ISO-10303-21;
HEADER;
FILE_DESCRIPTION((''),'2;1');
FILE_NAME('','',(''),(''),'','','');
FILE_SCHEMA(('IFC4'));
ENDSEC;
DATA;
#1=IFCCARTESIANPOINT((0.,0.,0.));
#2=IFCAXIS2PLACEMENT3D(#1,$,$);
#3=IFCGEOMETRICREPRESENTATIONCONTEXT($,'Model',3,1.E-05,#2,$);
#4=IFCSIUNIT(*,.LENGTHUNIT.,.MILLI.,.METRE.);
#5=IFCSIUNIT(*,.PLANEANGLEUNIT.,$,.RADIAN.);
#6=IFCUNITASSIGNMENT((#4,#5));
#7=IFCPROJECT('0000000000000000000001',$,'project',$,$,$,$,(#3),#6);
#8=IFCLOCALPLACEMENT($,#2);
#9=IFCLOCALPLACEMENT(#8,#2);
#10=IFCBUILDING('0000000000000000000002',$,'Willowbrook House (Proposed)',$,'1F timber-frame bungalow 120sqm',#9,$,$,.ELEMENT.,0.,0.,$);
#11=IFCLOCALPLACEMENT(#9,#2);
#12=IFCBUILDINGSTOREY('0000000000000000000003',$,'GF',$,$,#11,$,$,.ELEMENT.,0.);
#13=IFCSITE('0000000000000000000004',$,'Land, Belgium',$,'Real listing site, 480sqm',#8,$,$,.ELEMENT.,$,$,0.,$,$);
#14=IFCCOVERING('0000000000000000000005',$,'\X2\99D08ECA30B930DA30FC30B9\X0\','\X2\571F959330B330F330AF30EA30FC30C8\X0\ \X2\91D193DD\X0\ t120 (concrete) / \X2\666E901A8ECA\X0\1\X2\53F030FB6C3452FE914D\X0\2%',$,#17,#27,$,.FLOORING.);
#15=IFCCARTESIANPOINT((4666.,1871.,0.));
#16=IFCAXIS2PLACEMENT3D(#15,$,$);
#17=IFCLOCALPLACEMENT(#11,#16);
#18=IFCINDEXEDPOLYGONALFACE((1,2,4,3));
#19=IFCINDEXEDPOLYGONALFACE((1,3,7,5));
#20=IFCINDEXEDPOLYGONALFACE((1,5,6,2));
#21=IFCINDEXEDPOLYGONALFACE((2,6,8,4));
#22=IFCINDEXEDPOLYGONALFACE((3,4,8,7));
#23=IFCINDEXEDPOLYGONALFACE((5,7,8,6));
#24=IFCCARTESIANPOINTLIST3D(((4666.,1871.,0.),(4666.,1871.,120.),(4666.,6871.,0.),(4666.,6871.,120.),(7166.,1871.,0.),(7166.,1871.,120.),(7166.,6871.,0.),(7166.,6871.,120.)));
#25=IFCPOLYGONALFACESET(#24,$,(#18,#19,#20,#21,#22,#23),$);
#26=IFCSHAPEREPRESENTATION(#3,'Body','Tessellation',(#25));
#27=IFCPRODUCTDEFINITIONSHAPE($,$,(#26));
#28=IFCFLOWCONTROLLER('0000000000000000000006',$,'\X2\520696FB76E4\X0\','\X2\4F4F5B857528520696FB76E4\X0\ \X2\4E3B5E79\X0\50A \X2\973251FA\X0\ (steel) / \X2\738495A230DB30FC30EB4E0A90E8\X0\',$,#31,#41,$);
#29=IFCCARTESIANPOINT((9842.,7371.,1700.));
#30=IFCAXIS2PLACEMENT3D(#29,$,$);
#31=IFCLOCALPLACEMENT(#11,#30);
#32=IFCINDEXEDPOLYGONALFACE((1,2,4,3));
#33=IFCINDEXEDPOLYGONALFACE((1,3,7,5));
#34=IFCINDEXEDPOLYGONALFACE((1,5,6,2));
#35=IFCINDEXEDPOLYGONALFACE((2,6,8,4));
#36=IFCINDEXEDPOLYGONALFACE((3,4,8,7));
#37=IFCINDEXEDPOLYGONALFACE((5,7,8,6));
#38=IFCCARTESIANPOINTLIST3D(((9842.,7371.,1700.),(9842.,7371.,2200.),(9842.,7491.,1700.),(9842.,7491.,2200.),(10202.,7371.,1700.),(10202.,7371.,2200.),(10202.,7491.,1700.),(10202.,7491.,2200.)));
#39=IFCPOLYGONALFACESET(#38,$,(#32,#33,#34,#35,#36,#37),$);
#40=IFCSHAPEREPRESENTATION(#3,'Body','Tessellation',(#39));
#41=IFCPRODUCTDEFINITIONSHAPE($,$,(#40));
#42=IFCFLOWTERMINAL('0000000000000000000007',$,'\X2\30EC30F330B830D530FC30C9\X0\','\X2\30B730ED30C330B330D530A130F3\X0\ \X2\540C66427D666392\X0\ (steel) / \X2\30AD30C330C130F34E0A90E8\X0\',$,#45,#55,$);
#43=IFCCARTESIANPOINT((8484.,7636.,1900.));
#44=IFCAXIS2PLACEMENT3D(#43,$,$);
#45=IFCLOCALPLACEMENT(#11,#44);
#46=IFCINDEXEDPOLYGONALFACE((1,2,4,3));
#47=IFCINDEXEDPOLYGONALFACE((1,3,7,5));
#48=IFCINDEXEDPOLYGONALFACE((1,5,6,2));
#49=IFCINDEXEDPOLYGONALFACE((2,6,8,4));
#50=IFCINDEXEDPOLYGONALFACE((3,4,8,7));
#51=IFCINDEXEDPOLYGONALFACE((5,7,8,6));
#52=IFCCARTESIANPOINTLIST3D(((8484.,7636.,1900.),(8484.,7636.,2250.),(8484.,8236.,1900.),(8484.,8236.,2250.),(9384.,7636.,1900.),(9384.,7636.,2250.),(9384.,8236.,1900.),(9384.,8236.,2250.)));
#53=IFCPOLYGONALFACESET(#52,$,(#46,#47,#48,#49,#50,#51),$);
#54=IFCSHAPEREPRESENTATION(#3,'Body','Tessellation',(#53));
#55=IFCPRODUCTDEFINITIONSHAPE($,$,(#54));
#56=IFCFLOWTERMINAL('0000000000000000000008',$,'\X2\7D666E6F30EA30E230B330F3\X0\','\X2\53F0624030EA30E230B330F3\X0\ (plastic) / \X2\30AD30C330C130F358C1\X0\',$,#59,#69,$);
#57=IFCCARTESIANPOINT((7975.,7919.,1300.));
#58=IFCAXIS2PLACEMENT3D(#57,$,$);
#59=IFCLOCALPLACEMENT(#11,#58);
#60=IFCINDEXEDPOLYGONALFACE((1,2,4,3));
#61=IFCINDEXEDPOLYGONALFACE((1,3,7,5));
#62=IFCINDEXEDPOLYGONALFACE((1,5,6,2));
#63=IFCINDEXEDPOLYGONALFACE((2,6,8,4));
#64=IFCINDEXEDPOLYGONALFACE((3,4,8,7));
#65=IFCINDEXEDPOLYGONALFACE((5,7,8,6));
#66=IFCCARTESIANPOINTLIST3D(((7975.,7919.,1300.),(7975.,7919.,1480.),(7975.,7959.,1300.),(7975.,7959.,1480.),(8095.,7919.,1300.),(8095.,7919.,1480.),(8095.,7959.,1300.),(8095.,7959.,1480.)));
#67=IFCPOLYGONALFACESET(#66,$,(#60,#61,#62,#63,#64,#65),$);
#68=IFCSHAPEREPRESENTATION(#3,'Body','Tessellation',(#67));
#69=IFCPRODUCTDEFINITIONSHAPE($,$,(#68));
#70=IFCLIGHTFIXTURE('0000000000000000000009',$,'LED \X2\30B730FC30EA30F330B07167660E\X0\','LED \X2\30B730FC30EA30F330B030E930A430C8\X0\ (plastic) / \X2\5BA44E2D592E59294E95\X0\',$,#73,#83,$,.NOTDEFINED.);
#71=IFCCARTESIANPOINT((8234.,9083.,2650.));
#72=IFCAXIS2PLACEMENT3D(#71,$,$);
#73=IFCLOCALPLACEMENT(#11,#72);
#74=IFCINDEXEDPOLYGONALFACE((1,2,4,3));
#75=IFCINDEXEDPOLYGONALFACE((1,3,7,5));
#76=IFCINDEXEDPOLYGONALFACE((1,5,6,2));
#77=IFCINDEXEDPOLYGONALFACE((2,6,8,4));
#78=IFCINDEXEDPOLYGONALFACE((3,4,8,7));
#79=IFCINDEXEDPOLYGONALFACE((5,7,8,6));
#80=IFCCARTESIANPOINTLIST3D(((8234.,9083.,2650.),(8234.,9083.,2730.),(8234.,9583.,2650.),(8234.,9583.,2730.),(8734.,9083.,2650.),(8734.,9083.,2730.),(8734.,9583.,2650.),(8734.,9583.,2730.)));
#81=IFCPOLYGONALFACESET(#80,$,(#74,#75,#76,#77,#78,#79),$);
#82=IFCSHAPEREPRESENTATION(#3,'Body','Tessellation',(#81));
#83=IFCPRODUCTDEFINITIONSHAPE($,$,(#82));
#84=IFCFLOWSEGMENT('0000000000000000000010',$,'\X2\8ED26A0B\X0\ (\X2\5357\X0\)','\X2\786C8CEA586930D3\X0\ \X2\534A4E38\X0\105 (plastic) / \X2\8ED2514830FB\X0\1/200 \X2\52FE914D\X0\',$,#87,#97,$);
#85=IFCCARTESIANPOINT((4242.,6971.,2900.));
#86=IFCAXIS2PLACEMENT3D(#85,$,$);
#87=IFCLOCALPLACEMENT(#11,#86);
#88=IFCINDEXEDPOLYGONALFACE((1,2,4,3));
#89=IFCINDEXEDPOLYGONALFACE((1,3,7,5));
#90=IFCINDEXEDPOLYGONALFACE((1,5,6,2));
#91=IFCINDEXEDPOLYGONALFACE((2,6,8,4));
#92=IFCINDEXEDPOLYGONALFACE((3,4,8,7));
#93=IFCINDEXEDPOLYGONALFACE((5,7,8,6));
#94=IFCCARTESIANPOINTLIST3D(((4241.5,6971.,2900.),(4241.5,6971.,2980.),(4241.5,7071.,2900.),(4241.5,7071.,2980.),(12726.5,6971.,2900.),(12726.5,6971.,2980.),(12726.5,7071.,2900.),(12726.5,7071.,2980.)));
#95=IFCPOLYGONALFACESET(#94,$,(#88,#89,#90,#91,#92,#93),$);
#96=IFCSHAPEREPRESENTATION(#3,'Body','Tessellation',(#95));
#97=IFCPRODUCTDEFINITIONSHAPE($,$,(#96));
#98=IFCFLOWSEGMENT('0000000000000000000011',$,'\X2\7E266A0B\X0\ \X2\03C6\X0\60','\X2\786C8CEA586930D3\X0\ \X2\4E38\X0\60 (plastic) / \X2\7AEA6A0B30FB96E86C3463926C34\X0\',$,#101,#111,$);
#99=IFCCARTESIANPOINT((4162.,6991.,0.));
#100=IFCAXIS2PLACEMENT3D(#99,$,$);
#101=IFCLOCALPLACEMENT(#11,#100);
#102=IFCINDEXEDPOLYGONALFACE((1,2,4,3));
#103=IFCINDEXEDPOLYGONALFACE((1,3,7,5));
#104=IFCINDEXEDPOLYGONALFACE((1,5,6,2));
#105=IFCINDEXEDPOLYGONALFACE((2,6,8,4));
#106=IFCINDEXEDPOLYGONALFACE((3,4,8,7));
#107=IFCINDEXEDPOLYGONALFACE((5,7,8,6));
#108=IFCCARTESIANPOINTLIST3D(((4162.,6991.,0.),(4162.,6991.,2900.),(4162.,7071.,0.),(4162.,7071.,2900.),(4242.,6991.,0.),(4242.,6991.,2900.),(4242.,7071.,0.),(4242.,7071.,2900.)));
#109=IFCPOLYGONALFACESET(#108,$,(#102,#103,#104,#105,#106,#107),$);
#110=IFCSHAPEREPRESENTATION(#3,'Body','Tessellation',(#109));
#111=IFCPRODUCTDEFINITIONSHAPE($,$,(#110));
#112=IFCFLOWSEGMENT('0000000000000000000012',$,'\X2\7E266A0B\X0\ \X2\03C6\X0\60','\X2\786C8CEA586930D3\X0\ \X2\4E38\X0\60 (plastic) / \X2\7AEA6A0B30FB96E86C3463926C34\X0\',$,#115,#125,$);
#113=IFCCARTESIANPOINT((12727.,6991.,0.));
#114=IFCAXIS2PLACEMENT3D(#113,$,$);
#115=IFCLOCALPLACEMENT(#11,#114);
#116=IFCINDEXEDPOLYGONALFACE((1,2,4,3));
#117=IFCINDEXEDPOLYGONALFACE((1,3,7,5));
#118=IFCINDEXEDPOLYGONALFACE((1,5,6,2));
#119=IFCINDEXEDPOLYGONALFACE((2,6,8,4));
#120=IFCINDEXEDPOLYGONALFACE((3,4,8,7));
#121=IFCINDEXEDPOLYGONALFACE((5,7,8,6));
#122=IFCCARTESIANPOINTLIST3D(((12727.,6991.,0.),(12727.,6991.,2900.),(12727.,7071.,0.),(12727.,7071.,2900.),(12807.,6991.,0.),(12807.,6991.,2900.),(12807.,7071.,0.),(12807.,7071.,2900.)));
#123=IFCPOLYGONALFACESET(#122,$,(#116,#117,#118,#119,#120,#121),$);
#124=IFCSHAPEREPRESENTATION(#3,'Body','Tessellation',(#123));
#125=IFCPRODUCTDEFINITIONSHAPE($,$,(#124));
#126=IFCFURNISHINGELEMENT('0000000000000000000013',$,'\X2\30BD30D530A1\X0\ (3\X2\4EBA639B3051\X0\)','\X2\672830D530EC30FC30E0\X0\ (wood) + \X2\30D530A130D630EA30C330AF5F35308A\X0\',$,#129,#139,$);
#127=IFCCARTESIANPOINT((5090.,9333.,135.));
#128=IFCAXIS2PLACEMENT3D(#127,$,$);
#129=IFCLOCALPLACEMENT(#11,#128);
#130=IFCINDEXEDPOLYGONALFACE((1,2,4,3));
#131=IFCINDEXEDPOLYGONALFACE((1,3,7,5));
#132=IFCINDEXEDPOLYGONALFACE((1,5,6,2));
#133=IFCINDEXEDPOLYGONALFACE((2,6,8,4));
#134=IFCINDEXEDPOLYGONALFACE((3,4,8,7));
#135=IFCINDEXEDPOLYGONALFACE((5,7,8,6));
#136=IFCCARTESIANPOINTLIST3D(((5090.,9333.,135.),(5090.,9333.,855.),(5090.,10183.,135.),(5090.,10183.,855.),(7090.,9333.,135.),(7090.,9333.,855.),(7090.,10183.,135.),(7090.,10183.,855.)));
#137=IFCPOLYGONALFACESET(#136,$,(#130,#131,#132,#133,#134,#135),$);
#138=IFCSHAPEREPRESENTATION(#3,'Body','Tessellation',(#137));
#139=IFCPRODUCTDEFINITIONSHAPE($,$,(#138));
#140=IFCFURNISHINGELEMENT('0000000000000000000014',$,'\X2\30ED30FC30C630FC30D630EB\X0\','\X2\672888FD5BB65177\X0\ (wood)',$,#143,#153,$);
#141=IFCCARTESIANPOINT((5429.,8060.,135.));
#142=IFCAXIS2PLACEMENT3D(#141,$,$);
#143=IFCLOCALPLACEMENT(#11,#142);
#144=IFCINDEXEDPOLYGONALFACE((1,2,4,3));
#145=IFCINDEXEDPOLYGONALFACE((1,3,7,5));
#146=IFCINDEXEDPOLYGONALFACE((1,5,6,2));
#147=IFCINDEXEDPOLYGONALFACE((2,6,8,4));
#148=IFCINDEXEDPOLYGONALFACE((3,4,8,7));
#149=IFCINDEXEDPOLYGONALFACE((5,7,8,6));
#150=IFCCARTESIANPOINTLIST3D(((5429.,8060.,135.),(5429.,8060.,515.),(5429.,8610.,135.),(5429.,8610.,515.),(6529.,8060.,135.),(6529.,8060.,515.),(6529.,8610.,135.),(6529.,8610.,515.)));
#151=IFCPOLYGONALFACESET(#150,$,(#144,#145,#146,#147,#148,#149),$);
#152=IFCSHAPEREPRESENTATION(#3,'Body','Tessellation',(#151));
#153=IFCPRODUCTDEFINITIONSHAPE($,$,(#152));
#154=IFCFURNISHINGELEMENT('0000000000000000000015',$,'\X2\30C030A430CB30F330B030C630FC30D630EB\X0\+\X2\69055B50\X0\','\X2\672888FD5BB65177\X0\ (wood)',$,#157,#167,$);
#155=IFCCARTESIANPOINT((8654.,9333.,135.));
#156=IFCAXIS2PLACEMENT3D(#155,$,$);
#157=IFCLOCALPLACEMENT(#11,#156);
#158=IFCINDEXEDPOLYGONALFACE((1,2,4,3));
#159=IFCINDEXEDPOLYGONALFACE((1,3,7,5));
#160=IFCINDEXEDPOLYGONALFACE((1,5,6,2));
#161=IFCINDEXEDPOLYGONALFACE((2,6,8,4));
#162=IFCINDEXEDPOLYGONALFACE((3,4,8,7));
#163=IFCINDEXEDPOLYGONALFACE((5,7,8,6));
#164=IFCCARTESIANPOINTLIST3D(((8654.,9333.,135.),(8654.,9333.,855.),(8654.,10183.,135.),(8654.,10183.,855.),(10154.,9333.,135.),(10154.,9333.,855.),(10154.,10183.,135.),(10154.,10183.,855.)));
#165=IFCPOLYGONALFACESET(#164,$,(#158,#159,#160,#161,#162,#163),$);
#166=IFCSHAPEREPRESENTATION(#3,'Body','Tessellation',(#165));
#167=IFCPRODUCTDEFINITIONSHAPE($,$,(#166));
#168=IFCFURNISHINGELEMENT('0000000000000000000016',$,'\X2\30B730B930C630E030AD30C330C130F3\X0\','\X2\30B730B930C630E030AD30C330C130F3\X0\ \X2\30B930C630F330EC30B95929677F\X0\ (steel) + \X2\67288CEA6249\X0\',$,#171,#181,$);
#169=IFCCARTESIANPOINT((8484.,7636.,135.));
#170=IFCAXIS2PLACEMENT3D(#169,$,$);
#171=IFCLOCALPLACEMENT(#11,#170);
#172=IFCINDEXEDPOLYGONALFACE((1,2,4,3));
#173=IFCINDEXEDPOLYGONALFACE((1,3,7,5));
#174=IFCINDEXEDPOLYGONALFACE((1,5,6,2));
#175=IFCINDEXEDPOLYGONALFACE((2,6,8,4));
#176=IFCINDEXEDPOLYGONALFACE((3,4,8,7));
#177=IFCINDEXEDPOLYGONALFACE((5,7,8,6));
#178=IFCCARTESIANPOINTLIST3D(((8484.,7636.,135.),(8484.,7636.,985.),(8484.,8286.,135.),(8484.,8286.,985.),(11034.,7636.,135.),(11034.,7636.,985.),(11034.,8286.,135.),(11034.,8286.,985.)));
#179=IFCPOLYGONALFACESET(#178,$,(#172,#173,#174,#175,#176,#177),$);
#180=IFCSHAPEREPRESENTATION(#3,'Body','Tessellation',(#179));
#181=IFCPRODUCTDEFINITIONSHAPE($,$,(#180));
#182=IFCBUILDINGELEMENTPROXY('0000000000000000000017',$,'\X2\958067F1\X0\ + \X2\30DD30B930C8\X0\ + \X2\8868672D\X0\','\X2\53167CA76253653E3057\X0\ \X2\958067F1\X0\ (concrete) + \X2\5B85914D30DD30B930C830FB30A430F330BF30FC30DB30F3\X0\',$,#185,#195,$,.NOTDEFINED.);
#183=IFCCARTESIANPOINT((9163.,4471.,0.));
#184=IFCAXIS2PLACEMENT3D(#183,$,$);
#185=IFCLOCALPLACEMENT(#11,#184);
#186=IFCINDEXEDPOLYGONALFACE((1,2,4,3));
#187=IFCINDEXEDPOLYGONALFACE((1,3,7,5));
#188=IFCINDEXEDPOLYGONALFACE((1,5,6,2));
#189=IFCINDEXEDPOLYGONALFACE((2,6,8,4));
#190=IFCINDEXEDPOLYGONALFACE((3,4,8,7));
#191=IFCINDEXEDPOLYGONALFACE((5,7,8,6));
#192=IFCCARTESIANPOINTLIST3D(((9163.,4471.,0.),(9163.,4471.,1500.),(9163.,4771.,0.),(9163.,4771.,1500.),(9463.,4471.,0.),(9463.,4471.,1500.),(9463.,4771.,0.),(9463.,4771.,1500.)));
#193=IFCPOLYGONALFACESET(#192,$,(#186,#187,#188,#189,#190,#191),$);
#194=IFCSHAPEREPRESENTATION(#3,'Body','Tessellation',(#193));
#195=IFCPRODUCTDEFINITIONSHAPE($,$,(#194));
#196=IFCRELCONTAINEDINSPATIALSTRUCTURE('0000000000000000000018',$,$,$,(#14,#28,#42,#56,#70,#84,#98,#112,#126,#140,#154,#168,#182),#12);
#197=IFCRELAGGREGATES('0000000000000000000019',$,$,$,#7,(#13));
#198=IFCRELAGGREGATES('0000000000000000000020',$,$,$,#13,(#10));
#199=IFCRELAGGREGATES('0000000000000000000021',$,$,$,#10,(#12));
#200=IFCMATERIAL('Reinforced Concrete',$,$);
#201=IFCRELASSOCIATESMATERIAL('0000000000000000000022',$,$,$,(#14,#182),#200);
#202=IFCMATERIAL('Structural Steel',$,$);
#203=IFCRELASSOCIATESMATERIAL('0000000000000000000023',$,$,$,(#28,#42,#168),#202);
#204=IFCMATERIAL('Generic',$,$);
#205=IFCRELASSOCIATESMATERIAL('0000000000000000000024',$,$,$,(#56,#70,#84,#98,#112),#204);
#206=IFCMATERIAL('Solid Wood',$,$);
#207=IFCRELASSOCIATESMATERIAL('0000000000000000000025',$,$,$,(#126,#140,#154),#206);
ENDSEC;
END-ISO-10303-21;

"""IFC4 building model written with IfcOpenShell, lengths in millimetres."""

from ifc_helpers import new_model, si_unit, frame, frame_2d, origin, place, context, project, spatial, rectangle, extrude, material, element, save


model = new_model("IFC4")

# Units and contexts
model_context = context("Model", 3, precision=1e-05, world=origin())
ifc_project = project(units=[si_unit("LENGTHUNIT", "METRE", prefix="MILLI"), si_unit("PLANEANGLEUNIT", "RADIAN")], contexts=[model_context])

# Site, building, storey
site_placement = place(None, origin())
site = spatial("IfcSite", under=ifc_project, at=site_placement, Name="Land, Belgium", ObjectType="Real listing site, 480sqm", CompositionType="ELEMENT", RefElevation=0.0)
building_placement = place(site_placement, origin())
building = spatial("IfcBuilding", under=site, at=building_placement, Name="Willowbrook House (Proposed)", ObjectType="1F timber-frame bungalow 120sqm", CompositionType="ELEMENT", ElevationOfRefHeight=0.0, ElevationOfTerrain=0.0)
storey_placement = place(building_placement, origin())
storey = spatial("IfcBuildingStorey", under=building, at=storey_placement, Name="GF", CompositionType="ELEMENT", Elevation=0.0)

# Shared definitions
ifc_material_1 = material(Name="Solid Wood")

# Shared definitions
ifc_material_2 = material(Name="Reinforced Concrete")

# Shared definitions
ifc_material_3 = material(Name="Structural Steel")

# Covering
ifc_material_4 = material(Name="Generic")
covering_1_placement = place(storey_placement, frame((4666.0, 1871.0, 0.0)))
element("IfcCovering", 1, at=covering_1_placement, inside=storey, material=ifc_material_2, Name="駐車スペース", Description="土間コンクリート 金鏝 t120 (concrete) / 普通車1台・水勾配2%", PredefinedType="FLOORING", context=model_context, shape_type="SweptSolid", body=[
    extrude(rectangle(XDim=2500.0, YDim=5000.0, at=frame_2d((1250.0, 2500.0))), frame((4666.0, 1871.0, 0.0)), (0.0, 0.0, 1.0), 120.0),
])

# Flow controller
flow_controller_placement = place(storey_placement, frame((9842.0, 7371.0, 1700.0)))
element("IfcFlowController", 2, at=flow_controller_placement, inside=storey, material=ifc_material_3, Name="分電盤", Description="住宅用分電盤 主幹50A 露出 (steel) / 玄関ホール上部", context=model_context, shape_type="SweptSolid", body=[
    extrude(rectangle(XDim=360.0, YDim=120.0, at=frame_2d((180.0, 60.0))), frame((9842.0, 7371.0, 1700.0)), (0.0, 0.0, 1.0), 500.0),
])

# Flow terminals
flow_terminal_1_placement = place(storey_placement, frame((8484.0, 7636.0, 1900.0)))
element("IfcFlowTerminal", 3, at=flow_terminal_1_placement, inside=storey, material=ifc_material_3, Name="レンジフード", Description="シロッコファン 同時給排 (steel) / キッチン上部", context=model_context, shape_type="SweptSolid", body=[
    extrude(rectangle(XDim=900.0, YDim=600.0, at=frame_2d((450.0, 300.0))), frame((8484.0, 7636.0, 1900.0)), (0.0, 0.0, 1.0), 350.0),
])
flow_terminal_2_placement = place(storey_placement, frame((7975.0, 7919.0, 1300.0)))
element("IfcFlowTerminal", 4, at=flow_terminal_2_placement, inside=storey, material=ifc_material_4, Name="給湯リモコン", Description="台所リモコン (plastic) / キッチン壁", context=model_context, shape_type="SweptSolid", body=[
    extrude(rectangle(XDim=120.0, YDim=40.0, at=frame_2d((60.0, 20.0))), frame((7975.0, 7919.0, 1300.0)), (0.0, 0.0, 1.0), 180.0),
])

# Light fixture
light_fixture_placement = place(storey_placement, frame((8234.0, 9083.0, 2650.0)))
element("IfcLightFixture", 5, at=light_fixture_placement, inside=storey, material=ifc_material_4, Name="LED シーリング照明", Description="LED シーリングライト (plastic) / 室中央天井", PredefinedType="NOTDEFINED", context=model_context, shape_type="SweptSolid", body=[
    extrude(rectangle(XDim=500.0, YDim=500.0, at=frame_2d((250.0, 250.0))), frame((8234.0, 9083.0, 2650.0)), (0.0, 0.0, 1.0), 80.0),
])

# Flow segments
flow_segment_1_placement = place(storey_placement, frame((4242.0, 6971.0, 2900.0)))
element("IfcFlowSegment", 6, at=flow_segment_1_placement, inside=storey, material=ifc_material_4, Name="軒樋 (南)", Description="硬質塩ビ 半丸105 (plastic) / 軒先・1/200 勾配", context=model_context, shape_type="SweptSolid", body=[
    extrude(rectangle(XDim=8485.0, YDim=100.0, at=frame_2d((4242.0, 50.0))), frame((4242.0, 6971.0, 2900.0)), (0.0, 0.0, 1.0), 80.0),
])
flow_segment_2_placement = place(storey_placement, frame((4162.0, 6991.0, 0.0)))
element("IfcFlowSegment", 7, at=flow_segment_2_placement, inside=storey, material=ifc_material_4, Name="縦樋 φ60", Description="硬質塩ビ 丸60 (plastic) / 竪樋・雨水排水", context=model_context, shape_type="SweptSolid", body=[
    extrude(rectangle(XDim=80.0, YDim=80.0, at=frame_2d((40.0, 40.0))), frame((4162.0, 6991.0, 0.0)), (0.0, 0.0, 1.0), 2900.0),
])
flow_segment_3_placement = place(storey_placement, frame((12727.0, 6991.0, 0.0)))
element("IfcFlowSegment", 8, at=flow_segment_3_placement, inside=storey, material=ifc_material_4, Name="縦樋 φ60", Description="硬質塩ビ 丸60 (plastic) / 竪樋・雨水排水", context=model_context, shape_type="SweptSolid", body=[
    extrude(rectangle(XDim=80.0, YDim=80.0, at=frame_2d((40.0, 40.0))), frame((12727.0, 6991.0, 0.0)), (0.0, 0.0, 1.0), 2900.0),
])

# Furnishing elements
furnishing_1_placement = place(storey_placement, frame((5090.0, 9333.0, 135.0)))
element("IfcFurnishingElement", 9, at=furnishing_1_placement, inside=storey, material=ifc_material_1, Name="ソファ (3人掛け)", Description="木フレーム (wood) + ファブリック張り", context=model_context, shape_type="SweptSolid", body=[
    extrude(rectangle(XDim=2000.0, YDim=850.0, at=frame_2d((1000.0, 425.0))), frame((5090.0, 9333.0, 135.0)), (0.0, 0.0, 1.0), 720.0),
])
furnishing_2_placement = place(storey_placement, frame((5429.0, 8060.0, 135.0)))
element("IfcFurnishingElement", 10, at=furnishing_2_placement, inside=storey, material=ifc_material_1, Name="ローテーブル", Description="木製家具 (wood)", context=model_context, shape_type="SweptSolid", body=[
    extrude(rectangle(XDim=1100.0, YDim=550.0, at=frame_2d((550.0, 275.0))), frame((5429.0, 8060.0, 135.0)), (0.0, 0.0, 1.0), 380.0),
])
furnishing_3_placement = place(storey_placement, frame((8654.0, 9333.0, 135.0)))
element("IfcFurnishingElement", 11, at=furnishing_3_placement, inside=storey, material=ifc_material_1, Name="ダイニングテーブル+椅子", Description="木製家具 (wood)", context=model_context, shape_type="SweptSolid", body=[
    extrude(rectangle(XDim=1500.0, YDim=850.0, at=frame_2d((750.0, 425.0))), frame((8654.0, 9333.0, 135.0)), (0.0, 0.0, 1.0), 720.0),
])
furnishing_4_placement = place(storey_placement, frame((8484.0, 7636.0, 135.0)))
element("IfcFurnishingElement", 12, at=furnishing_4_placement, inside=storey, material=ifc_material_3, Name="システムキッチン", Description="システムキッチン ステンレス天板 (steel) + 木質扉", context=model_context, shape_type="SweptSolid", body=[
    extrude(rectangle(XDim=2550.0, YDim=650.0, at=frame_2d((1275.0, 325.0))), frame((8484.0, 7636.0, 135.0)), (0.0, 0.0, 1.0), 850.0),
])

# Building element proxy
proxy_placement = place(storey_placement, frame((9163.0, 4471.0, 0.0)))
element("IfcBuildingElementProxy", 13, at=proxy_placement, inside=storey, material=ifc_material_2, Name="門柱 + ポスト + 表札", Description="化粧打放し 門柱 (concrete) + 宅配ポスト・インターホン", PredefinedType="NOTDEFINED", context=model_context, shape_type="SweptSolid", body=[
    extrude(rectangle(XDim=300.0, YDim=300.0, at=frame_2d((150.0, 150.0))), frame((9163.0, 4471.0, 0.0)), (0.0, 0.0, 1.0), 1500.0),
])

save(model, "model.ifc")
